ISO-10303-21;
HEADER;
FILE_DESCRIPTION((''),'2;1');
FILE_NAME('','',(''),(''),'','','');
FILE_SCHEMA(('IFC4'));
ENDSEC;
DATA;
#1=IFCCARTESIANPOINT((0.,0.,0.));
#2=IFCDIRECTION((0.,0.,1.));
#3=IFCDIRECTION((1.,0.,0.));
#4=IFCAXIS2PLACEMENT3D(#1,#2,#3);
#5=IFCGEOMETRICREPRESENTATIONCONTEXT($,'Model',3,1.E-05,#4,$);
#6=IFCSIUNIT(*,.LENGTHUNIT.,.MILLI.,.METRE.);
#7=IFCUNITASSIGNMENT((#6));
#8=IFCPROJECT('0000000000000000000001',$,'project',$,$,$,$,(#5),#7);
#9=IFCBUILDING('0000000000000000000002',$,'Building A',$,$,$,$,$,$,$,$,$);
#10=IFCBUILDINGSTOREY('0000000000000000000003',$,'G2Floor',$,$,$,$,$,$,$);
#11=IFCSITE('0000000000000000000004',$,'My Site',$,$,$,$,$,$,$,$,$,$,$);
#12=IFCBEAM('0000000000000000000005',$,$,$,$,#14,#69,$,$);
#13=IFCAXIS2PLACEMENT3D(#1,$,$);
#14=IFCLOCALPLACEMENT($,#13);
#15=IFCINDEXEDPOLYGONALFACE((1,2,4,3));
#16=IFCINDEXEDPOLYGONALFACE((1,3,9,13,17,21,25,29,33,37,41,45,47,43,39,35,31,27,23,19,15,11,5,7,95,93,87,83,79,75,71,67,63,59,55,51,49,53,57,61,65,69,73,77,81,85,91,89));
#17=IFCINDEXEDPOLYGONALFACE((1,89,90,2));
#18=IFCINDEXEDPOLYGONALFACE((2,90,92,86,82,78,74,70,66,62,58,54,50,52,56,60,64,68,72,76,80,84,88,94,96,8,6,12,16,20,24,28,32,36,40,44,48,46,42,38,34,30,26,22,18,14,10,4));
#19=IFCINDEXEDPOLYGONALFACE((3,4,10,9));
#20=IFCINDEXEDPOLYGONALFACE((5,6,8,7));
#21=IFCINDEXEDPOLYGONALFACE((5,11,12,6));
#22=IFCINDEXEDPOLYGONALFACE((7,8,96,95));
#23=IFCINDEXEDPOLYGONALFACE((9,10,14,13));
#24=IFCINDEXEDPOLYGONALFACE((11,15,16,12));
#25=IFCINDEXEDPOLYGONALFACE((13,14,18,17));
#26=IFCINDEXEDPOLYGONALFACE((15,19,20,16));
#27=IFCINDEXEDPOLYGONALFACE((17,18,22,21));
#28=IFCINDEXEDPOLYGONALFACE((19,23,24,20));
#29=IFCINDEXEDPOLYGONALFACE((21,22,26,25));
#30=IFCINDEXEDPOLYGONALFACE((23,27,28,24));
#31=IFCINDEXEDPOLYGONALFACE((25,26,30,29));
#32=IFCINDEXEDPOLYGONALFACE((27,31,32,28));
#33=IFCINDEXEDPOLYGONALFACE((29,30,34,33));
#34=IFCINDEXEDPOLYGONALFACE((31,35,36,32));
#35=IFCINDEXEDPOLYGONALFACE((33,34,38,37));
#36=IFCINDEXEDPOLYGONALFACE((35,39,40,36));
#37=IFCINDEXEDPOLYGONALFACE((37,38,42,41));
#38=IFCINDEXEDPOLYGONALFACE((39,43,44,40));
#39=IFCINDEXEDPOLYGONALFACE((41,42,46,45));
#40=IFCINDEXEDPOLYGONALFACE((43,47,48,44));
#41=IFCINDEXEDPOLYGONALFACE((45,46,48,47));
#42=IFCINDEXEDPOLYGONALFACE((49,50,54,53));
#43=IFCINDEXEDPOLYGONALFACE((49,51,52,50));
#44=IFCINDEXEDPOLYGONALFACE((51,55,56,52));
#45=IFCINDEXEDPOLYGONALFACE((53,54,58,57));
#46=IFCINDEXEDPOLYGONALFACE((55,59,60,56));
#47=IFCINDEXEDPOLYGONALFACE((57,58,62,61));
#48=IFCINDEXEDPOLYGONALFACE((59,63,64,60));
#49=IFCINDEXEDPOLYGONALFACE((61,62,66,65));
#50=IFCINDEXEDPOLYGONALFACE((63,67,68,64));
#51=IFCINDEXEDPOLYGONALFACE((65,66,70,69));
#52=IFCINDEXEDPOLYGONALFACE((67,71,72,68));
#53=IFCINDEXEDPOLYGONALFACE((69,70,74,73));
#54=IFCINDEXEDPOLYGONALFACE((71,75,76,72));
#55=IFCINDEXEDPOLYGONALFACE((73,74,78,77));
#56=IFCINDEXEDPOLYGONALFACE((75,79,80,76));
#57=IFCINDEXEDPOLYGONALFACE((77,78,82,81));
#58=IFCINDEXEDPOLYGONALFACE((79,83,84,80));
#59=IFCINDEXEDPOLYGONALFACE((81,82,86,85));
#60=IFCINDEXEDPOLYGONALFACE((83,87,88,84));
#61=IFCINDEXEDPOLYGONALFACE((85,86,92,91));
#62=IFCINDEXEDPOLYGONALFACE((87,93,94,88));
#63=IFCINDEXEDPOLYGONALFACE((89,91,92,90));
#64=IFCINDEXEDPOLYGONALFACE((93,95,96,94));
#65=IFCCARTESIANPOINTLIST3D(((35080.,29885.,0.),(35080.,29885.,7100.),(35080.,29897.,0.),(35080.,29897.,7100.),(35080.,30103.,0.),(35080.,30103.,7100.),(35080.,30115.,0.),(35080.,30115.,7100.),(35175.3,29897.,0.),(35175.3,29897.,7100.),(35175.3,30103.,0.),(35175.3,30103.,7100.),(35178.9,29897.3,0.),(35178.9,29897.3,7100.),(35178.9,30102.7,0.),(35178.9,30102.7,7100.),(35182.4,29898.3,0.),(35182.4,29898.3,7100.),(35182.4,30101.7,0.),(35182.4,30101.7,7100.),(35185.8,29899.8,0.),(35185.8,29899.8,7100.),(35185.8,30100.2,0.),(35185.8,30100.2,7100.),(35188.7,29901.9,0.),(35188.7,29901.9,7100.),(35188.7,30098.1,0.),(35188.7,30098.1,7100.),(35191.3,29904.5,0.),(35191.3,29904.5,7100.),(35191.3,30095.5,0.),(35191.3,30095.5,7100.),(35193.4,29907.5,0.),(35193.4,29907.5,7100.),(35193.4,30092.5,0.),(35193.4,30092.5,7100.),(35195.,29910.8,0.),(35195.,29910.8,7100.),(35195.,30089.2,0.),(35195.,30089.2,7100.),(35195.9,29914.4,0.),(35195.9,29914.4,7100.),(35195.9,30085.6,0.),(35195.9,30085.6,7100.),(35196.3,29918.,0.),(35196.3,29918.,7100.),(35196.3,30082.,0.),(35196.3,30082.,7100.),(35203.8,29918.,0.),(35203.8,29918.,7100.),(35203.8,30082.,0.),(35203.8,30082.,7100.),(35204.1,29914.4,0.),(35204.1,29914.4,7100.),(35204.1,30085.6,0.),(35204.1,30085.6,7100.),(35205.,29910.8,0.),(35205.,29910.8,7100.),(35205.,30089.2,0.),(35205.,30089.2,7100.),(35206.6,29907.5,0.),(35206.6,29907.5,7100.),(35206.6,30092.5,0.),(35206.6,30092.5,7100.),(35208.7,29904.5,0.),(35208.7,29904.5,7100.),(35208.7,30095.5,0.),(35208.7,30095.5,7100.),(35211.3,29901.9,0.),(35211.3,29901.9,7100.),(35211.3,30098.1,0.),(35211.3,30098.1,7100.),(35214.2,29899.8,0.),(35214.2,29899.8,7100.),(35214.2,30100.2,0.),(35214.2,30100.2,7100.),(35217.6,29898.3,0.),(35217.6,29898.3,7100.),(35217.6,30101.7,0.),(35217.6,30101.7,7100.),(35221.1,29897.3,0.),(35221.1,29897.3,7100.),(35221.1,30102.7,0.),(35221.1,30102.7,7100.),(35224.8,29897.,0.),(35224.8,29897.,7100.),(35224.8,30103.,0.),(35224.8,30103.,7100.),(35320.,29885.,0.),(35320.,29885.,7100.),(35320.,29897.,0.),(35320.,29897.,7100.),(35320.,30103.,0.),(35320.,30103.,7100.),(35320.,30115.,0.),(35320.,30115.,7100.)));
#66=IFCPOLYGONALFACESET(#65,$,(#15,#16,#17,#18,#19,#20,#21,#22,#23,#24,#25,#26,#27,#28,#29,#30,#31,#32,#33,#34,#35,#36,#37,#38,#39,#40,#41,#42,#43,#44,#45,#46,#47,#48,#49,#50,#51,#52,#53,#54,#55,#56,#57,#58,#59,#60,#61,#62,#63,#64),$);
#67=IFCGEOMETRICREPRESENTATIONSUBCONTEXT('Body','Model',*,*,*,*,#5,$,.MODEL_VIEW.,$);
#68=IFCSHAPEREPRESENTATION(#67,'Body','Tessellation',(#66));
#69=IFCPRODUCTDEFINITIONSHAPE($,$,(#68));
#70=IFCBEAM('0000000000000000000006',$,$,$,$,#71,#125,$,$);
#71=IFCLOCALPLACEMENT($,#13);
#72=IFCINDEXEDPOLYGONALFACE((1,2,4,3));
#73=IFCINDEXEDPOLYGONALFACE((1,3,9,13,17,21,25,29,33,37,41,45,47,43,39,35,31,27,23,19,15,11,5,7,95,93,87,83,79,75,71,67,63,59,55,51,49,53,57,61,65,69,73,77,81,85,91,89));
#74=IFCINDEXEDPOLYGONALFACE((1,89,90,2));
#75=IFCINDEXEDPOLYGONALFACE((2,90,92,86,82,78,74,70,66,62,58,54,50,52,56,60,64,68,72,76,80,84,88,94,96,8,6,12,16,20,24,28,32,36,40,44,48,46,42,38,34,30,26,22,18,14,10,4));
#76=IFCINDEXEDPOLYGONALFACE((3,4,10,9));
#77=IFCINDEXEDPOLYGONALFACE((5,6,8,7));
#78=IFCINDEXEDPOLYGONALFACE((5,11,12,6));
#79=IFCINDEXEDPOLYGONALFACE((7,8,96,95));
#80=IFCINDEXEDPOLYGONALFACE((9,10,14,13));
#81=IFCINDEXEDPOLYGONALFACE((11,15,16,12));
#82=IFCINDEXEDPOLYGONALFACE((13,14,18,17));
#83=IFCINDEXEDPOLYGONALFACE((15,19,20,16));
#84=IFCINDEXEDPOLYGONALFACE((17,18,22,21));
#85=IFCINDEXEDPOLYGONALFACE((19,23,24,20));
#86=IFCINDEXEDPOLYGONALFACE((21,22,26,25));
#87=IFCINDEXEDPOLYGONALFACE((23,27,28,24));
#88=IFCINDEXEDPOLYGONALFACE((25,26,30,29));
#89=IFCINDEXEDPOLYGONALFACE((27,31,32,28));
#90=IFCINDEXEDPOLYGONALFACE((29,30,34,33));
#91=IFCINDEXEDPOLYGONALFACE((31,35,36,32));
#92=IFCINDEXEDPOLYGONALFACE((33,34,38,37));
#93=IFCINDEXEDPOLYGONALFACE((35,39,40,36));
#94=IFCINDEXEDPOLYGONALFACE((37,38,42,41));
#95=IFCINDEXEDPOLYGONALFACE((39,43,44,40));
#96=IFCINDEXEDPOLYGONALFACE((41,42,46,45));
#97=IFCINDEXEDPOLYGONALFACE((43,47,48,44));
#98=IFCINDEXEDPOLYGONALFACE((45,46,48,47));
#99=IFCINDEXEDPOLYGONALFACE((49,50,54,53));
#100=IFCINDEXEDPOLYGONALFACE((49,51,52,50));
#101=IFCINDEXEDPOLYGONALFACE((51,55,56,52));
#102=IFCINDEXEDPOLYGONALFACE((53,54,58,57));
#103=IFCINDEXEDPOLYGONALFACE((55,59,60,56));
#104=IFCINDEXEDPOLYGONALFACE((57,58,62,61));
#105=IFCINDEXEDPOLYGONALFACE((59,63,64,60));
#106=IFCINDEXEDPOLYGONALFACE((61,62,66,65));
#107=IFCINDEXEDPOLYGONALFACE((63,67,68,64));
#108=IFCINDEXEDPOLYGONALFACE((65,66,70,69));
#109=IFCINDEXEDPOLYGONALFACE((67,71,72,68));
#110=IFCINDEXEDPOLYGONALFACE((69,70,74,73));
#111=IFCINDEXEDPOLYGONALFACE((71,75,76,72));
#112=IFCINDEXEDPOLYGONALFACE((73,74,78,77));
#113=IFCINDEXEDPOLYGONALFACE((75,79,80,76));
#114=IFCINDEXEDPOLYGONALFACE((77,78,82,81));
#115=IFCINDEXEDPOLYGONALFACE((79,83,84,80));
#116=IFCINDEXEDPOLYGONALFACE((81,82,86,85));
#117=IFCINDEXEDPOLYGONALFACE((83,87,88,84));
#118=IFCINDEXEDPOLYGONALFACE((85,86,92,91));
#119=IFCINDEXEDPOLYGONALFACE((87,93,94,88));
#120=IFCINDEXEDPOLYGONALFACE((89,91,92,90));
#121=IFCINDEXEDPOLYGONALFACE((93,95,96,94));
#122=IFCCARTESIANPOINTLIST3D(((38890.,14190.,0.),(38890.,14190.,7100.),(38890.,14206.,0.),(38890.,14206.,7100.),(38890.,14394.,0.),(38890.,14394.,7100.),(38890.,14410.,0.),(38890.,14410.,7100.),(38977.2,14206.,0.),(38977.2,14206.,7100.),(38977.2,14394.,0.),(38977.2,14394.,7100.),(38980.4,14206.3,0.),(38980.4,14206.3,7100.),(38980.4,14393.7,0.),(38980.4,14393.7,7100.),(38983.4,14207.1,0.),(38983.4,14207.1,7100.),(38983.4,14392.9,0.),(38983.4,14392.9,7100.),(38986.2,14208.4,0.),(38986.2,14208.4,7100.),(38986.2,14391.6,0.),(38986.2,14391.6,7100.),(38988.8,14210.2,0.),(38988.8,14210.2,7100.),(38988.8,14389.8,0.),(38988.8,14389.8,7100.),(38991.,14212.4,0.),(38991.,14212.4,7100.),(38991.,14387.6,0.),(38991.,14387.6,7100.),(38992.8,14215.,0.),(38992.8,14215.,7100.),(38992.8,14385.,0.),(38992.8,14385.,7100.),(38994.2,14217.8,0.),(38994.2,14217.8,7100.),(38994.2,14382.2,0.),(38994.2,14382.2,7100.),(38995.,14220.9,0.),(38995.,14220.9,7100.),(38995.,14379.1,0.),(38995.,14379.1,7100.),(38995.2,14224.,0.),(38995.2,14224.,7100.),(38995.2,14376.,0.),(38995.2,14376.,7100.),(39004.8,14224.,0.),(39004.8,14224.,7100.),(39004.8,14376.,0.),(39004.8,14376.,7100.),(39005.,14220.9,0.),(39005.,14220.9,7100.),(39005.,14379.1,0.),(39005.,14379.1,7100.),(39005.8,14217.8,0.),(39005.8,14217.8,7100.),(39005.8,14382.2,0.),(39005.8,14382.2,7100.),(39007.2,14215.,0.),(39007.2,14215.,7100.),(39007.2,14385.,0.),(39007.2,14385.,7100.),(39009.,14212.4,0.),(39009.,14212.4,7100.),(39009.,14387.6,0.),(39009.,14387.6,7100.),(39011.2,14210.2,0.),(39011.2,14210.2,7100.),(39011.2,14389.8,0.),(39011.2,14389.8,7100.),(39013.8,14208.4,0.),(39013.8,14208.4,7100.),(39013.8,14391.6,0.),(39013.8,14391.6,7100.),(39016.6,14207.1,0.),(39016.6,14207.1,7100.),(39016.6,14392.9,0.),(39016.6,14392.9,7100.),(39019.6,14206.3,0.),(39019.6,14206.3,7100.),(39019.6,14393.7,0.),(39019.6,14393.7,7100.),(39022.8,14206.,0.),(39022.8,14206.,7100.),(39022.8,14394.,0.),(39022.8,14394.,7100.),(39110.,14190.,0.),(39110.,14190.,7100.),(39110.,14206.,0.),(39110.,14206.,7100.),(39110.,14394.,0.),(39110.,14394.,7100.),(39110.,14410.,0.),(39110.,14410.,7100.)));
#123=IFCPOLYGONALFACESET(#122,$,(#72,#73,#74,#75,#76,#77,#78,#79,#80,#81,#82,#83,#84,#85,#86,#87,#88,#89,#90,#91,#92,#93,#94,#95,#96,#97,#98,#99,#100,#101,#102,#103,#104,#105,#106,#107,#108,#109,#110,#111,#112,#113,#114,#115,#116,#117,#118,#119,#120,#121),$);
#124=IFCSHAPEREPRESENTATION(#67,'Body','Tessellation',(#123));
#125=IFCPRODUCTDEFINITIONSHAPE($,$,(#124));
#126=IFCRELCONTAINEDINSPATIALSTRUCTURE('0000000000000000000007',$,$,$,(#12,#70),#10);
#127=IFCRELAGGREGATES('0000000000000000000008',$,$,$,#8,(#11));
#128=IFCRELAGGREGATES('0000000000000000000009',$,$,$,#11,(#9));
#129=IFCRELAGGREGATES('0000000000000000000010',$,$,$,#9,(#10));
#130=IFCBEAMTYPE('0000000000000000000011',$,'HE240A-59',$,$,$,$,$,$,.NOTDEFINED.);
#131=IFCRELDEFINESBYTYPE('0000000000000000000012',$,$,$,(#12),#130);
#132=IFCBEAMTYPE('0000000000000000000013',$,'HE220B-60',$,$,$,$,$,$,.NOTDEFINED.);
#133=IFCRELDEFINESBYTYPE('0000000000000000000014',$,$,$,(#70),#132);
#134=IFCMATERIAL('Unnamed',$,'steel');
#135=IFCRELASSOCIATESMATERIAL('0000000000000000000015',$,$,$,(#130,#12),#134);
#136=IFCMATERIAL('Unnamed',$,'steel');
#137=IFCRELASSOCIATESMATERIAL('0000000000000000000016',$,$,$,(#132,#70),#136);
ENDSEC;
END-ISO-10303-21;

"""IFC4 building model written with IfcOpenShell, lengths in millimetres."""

from ifc_helpers import new_model, si_unit, frame, origin_with_axes, place, context, subcontext, project, spatial, polyline, outline, extrude, material, material_profile, profile_set, profile_usage, type_object, element, save


model = new_model("IFC4")

# Units and contexts
model_context = context("Model", 3, precision=1e-05, world=origin_with_axes())
body_context = subcontext(model_context, "Body", "Model", "MODEL_VIEW")
ifc_project = project(units=[si_unit("LENGTHUNIT", "METRE", prefix="MILLI")], contexts=[model_context])

# Site, building, storey
site = spatial("IfcSite", under=ifc_project, Name="My Site")
building = spatial("IfcBuilding", under=site, Name="Building A")
storey = spatial("IfcBuildingStorey", under=building, Name="G2Floor")

# Beams
ifc_material_1 = material(Name="Unnamed", Category="steel")
ifc_material_profile_1 = material_profile(ifc_material_1, outline(polyline([(120.0, -115.0), (120.0, -103.0), (120.0, -103.0), (24.8, -103.0), (24.8, -103.0), (21.1, -102.7), (21.1, -102.7), (17.6, -101.7), (17.6, -101.7), (14.2, -100.2), (14.2, -100.2), (11.3, -98.1), (11.3, -98.1), (8.7, -95.5), (8.7, -95.5), (6.6, -92.5), (6.6, -92.5), (5.0, -89.2), (5.0, -89.2), (4.1, -85.6), (4.1, -85.6), (3.8, -82.0), (3.8, -82.0), (3.8, 82.0), (3.8, 82.0), (4.1, 85.6), (4.1, 85.6), (5.0, 89.2), (5.0, 89.2), (6.6, 92.5), (6.6, 92.5), (8.7, 95.5), (8.7, 95.5), (11.3, 98.1), (11.3, 98.1), (14.2, 100.2), (14.2, 100.2), (17.6, 101.7), (17.6, 101.7), (21.1, 102.7), (21.1, 102.7), (24.8, 103.0), (24.8, 103.0), (120.0, 103.0), (120.0, 103.0), (120.0, 115.0), (120.0, 115.0), (-120.0, 115.0), (-120.0, 115.0), (-120.0, 103.0), (-120.0, 103.0), (-24.8, 103.0), (-24.8, 103.0), (-21.1, 102.7), (-21.1, 102.7), (-17.6, 101.7), (-17.6, 101.7), (-14.2, 100.2), (-14.2, 100.2), (-11.3, 98.1), (-11.3, 98.1), (-8.7, 95.5), (-8.7, 95.5), (-6.6, 92.5), (-6.6, 92.5), (-5.0, 89.2), (-5.0, 89.2), (-4.1, 85.6), (-4.1, 85.6), (-3.8, 82.0), (-3.8, 82.0), (-3.8, -82.0), (-3.8, -82.0), (-4.1, -85.6), (-4.1, -85.6), (-5.0, -89.2), (-5.0, -89.2), (-6.6, -92.5), (-6.6, -92.5), (-8.7, -95.5), (-8.7, -95.5), (-11.3, -98.1), (-11.3, -98.1), (-14.2, -100.2), (-14.2, -100.2), (-17.6, -101.7), (-17.6, -101.7), (-21.1, -102.7), (-21.1, -102.7), (-24.8, -103.0), (-24.8, -103.0), (-120.0, -103.0), (-120.0, -103.0), (-120.0, -115.0), (-120.0, -115.0), (120.0, -115.0)])))
ifc_profile_set_1 = profile_set([ifc_material_profile_1], Name="HE240A-59")
ifc_profile_usage_1 = profile_usage(ifc_profile_set_1)
beam_type_1 = type_object("IfcBeamType", Name="HE240A-59", PredefinedType="NOTDEFINED", material=ifc_profile_set_1)
beam_1_placement = place(None, frame((35200.0, 30000.0, 0.0), z_axis=(0.0, 0.0, 1.0), x_axis=(1.0, 0.0, 0.0)))
element("IfcBeam", 1, at=beam_1_placement, inside=storey, type_object=beam_type_1, material=ifc_profile_usage_1, context=body_context, shape_type="SweptSolid", body=[
    extrude(outline(polyline([(120.0, -115.0), (120.0, -103.0), (120.0, -103.0), (24.8, -103.0), (24.8, -103.0), (21.1, -102.7), (21.1, -102.7), (17.6, -101.7), (17.6, -101.7), (14.2, -100.2), (14.2, -100.2), (11.3, -98.1), (11.3, -98.1), (8.7, -95.5), (8.7, -95.5), (6.6, -92.5), (6.6, -92.5), (5.0, -89.2), (5.0, -89.2), (4.1, -85.6), (4.1, -85.6), (3.8, -82.0), (3.8, -82.0), (3.8, 82.0), (3.8, 82.0), (4.1, 85.6), (4.1, 85.6), (5.0, 89.2), (5.0, 89.2), (6.6, 92.5), (6.6, 92.5), (8.7, 95.5), (8.7, 95.5), (11.3, 98.1), (11.3, 98.1), (14.2, 100.2), (14.2, 100.2), (17.6, 101.7), (17.6, 101.7), (21.1, 102.7), (21.1, 102.7), (24.8, 103.0), (24.8, 103.0), (120.0, 103.0), (120.0, 103.0), (120.0, 115.0), (120.0, 115.0), (-120.0, 115.0), (-120.0, 115.0), (-120.0, 103.0), (-120.0, 103.0), (-24.8, 103.0), (-24.8, 103.0), (-21.1, 102.7), (-21.1, 102.7), (-17.6, 101.7), (-17.6, 101.7), (-14.2, 100.2), (-14.2, 100.2), (-11.3, 98.1), (-11.3, 98.1), (-8.7, 95.5), (-8.7, 95.5), (-6.6, 92.5), (-6.6, 92.5), (-5.0, 89.2), (-5.0, 89.2), (-4.1, 85.6), (-4.1, 85.6), (-3.8, 82.0), (-3.8, 82.0), (-3.8, -82.0), (-3.8, -82.0), (-4.1, -85.6), (-4.1, -85.6), (-5.0, -89.2), (-5.0, -89.2), (-6.6, -92.5), (-6.6, -92.5), (-8.7, -95.5), (-8.7, -95.5), (-11.3, -98.1), (-11.3, -98.1), (-14.2, -100.2), (-14.2, -100.2), (-17.6, -101.7), (-17.6, -101.7), (-21.1, -102.7), (-21.1, -102.7), (-24.8, -103.0), (-24.8, -103.0), (-120.0, -103.0), (-120.0, -103.0), (-120.0, -115.0), (-120.0, -115.0), (120.0, -115.0)])), origin_with_axes(), (0.0, 0.0, 1.0), 7100.0),
])
ifc_material_2 = material(Name="Unnamed", Category="steel")
ifc_material_profile_2 = material_profile(ifc_material_2, outline(polyline([(110.0, -110.0), (110.0, -94.0), (110.0, -94.0), (22.8, -94.0), (22.8, -94.0), (19.6, -93.7), (19.6, -93.7), (16.6, -92.9), (16.6, -92.9), (13.8, -91.6), (13.8, -91.6), (11.2, -89.8), (11.2, -89.8), (9.0, -87.6), (9.0, -87.6), (7.2, -85.0), (7.2, -85.0), (5.8, -82.2), (5.8, -82.2), (5.0, -79.1), (5.0, -79.1), (4.8, -76.0), (4.8, -76.0), (4.8, 76.0), (4.8, 76.0), (5.0, 79.1), (5.0, 79.1), (5.8, 82.2), (5.8, 82.2), (7.2, 85.0), (7.2, 85.0), (9.0, 87.6), (9.0, 87.6), (11.2, 89.8), (11.2, 89.8), (13.8, 91.6), (13.8, 91.6), (16.6, 92.9), (16.6, 92.9), (19.6, 93.7), (19.6, 93.7), (22.8, 94.0), (22.8, 94.0), (110.0, 94.0), (110.0, 94.0), (110.0, 110.0), (110.0, 110.0), (-110.0, 110.0), (-110.0, 110.0), (-110.0, 94.0), (-110.0, 94.0), (-22.8, 94.0), (-22.8, 94.0), (-19.6, 93.7), (-19.6, 93.7), (-16.6, 92.9), (-16.6, 92.9), (-13.8, 91.6), (-13.8, 91.6), (-11.2, 89.8), (-11.2, 89.8), (-9.0, 87.6), (-9.0, 87.6), (-7.2, 85.0), (-7.2, 85.0), (-5.8, 82.2), (-5.8, 82.2), (-5.0, 79.1), (-5.0, 79.1), (-4.8, 76.0), (-4.8, 76.0), (-4.8, -76.0), (-4.8, -76.0), (-5.0, -79.1), (-5.0, -79.1), (-5.8, -82.2), (-5.8, -82.2), (-7.2, -85.0), (-7.2, -85.0), (-9.0, -87.6), (-9.0, -87.6), (-11.2, -89.8), (-11.2, -89.8), (-13.8, -91.6), (-13.8, -91.6), (-16.6, -92.9), (-16.6, -92.9), (-19.6, -93.7), (-19.6, -93.7), (-22.8, -94.0), (-22.8, -94.0), (-110.0, -94.0), (-110.0, -94.0), (-110.0, -110.0), (-110.0, -110.0), (110.0, -110.0)])))
ifc_profile_set_2 = profile_set([ifc_material_profile_2], Name="HE220B-60")
ifc_profile_usage_2 = profile_usage(ifc_profile_set_2)
beam_type_2 = type_object("IfcBeamType", Name="HE220B-60", PredefinedType="NOTDEFINED", material=ifc_profile_set_2)
beam_2_placement = place(None, frame((39000.0, 14300.0, 0.0), z_axis=(0.0, 0.0, 1.0), x_axis=(1.0, 0.0, 0.0)))
element("IfcBeam", 2, at=beam_2_placement, inside=storey, type_object=beam_type_2, material=ifc_profile_usage_2, context=body_context, shape_type="SweptSolid", body=[
    extrude(outline(polyline([(110.0, -110.0), (110.0, -94.0), (110.0, -94.0), (22.8, -94.0), (22.8, -94.0), (19.6, -93.7), (19.6, -93.7), (16.6, -92.9), (16.6, -92.9), (13.8, -91.6), (13.8, -91.6), (11.2, -89.8), (11.2, -89.8), (9.0, -87.6), (9.0, -87.6), (7.2, -85.0), (7.2, -85.0), (5.8, -82.2), (5.8, -82.2), (5.0, -79.1), (5.0, -79.1), (4.8, -76.0), (4.8, -76.0), (4.8, 76.0), (4.8, 76.0), (5.0, 79.1), (5.0, 79.1), (5.8, 82.2), (5.8, 82.2), (7.2, 85.0), (7.2, 85.0), (9.0, 87.6), (9.0, 87.6), (11.2, 89.8), (11.2, 89.8), (13.8, 91.6), (13.8, 91.6), (16.6, 92.9), (16.6, 92.9), (19.6, 93.7), (19.6, 93.7), (22.8, 94.0), (22.8, 94.0), (110.0, 94.0), (110.0, 94.0), (110.0, 110.0), (110.0, 110.0), (-110.0, 110.0), (-110.0, 110.0), (-110.0, 94.0), (-110.0, 94.0), (-22.8, 94.0), (-22.8, 94.0), (-19.6, 93.7), (-19.6, 93.7), (-16.6, 92.9), (-16.6, 92.9), (-13.8, 91.6), (-13.8, 91.6), (-11.2, 89.8), (-11.2, 89.8), (-9.0, 87.6), (-9.0, 87.6), (-7.2, 85.0), (-7.2, 85.0), (-5.8, 82.2), (-5.8, 82.2), (-5.0, 79.1), (-5.0, 79.1), (-4.8, 76.0), (-4.8, 76.0), (-4.8, -76.0), (-4.8, -76.0), (-5.0, -79.1), (-5.0, -79.1), (-5.8, -82.2), (-5.8, -82.2), (-7.2, -85.0), (-7.2, -85.0), (-9.0, -87.6), (-9.0, -87.6), (-11.2, -89.8), (-11.2, -89.8), (-13.8, -91.6), (-13.8, -91.6), (-16.6, -92.9), (-16.6, -92.9), (-19.6, -93.7), (-19.6, -93.7), (-22.8, -94.0), (-22.8, -94.0), (-110.0, -94.0), (-110.0, -94.0), (-110.0, -110.0), (-110.0, -110.0), (110.0, -110.0)])), origin_with_axes(), (0.0, 0.0, 1.0), 7100.0),
])

save(model, "model.ifc")
